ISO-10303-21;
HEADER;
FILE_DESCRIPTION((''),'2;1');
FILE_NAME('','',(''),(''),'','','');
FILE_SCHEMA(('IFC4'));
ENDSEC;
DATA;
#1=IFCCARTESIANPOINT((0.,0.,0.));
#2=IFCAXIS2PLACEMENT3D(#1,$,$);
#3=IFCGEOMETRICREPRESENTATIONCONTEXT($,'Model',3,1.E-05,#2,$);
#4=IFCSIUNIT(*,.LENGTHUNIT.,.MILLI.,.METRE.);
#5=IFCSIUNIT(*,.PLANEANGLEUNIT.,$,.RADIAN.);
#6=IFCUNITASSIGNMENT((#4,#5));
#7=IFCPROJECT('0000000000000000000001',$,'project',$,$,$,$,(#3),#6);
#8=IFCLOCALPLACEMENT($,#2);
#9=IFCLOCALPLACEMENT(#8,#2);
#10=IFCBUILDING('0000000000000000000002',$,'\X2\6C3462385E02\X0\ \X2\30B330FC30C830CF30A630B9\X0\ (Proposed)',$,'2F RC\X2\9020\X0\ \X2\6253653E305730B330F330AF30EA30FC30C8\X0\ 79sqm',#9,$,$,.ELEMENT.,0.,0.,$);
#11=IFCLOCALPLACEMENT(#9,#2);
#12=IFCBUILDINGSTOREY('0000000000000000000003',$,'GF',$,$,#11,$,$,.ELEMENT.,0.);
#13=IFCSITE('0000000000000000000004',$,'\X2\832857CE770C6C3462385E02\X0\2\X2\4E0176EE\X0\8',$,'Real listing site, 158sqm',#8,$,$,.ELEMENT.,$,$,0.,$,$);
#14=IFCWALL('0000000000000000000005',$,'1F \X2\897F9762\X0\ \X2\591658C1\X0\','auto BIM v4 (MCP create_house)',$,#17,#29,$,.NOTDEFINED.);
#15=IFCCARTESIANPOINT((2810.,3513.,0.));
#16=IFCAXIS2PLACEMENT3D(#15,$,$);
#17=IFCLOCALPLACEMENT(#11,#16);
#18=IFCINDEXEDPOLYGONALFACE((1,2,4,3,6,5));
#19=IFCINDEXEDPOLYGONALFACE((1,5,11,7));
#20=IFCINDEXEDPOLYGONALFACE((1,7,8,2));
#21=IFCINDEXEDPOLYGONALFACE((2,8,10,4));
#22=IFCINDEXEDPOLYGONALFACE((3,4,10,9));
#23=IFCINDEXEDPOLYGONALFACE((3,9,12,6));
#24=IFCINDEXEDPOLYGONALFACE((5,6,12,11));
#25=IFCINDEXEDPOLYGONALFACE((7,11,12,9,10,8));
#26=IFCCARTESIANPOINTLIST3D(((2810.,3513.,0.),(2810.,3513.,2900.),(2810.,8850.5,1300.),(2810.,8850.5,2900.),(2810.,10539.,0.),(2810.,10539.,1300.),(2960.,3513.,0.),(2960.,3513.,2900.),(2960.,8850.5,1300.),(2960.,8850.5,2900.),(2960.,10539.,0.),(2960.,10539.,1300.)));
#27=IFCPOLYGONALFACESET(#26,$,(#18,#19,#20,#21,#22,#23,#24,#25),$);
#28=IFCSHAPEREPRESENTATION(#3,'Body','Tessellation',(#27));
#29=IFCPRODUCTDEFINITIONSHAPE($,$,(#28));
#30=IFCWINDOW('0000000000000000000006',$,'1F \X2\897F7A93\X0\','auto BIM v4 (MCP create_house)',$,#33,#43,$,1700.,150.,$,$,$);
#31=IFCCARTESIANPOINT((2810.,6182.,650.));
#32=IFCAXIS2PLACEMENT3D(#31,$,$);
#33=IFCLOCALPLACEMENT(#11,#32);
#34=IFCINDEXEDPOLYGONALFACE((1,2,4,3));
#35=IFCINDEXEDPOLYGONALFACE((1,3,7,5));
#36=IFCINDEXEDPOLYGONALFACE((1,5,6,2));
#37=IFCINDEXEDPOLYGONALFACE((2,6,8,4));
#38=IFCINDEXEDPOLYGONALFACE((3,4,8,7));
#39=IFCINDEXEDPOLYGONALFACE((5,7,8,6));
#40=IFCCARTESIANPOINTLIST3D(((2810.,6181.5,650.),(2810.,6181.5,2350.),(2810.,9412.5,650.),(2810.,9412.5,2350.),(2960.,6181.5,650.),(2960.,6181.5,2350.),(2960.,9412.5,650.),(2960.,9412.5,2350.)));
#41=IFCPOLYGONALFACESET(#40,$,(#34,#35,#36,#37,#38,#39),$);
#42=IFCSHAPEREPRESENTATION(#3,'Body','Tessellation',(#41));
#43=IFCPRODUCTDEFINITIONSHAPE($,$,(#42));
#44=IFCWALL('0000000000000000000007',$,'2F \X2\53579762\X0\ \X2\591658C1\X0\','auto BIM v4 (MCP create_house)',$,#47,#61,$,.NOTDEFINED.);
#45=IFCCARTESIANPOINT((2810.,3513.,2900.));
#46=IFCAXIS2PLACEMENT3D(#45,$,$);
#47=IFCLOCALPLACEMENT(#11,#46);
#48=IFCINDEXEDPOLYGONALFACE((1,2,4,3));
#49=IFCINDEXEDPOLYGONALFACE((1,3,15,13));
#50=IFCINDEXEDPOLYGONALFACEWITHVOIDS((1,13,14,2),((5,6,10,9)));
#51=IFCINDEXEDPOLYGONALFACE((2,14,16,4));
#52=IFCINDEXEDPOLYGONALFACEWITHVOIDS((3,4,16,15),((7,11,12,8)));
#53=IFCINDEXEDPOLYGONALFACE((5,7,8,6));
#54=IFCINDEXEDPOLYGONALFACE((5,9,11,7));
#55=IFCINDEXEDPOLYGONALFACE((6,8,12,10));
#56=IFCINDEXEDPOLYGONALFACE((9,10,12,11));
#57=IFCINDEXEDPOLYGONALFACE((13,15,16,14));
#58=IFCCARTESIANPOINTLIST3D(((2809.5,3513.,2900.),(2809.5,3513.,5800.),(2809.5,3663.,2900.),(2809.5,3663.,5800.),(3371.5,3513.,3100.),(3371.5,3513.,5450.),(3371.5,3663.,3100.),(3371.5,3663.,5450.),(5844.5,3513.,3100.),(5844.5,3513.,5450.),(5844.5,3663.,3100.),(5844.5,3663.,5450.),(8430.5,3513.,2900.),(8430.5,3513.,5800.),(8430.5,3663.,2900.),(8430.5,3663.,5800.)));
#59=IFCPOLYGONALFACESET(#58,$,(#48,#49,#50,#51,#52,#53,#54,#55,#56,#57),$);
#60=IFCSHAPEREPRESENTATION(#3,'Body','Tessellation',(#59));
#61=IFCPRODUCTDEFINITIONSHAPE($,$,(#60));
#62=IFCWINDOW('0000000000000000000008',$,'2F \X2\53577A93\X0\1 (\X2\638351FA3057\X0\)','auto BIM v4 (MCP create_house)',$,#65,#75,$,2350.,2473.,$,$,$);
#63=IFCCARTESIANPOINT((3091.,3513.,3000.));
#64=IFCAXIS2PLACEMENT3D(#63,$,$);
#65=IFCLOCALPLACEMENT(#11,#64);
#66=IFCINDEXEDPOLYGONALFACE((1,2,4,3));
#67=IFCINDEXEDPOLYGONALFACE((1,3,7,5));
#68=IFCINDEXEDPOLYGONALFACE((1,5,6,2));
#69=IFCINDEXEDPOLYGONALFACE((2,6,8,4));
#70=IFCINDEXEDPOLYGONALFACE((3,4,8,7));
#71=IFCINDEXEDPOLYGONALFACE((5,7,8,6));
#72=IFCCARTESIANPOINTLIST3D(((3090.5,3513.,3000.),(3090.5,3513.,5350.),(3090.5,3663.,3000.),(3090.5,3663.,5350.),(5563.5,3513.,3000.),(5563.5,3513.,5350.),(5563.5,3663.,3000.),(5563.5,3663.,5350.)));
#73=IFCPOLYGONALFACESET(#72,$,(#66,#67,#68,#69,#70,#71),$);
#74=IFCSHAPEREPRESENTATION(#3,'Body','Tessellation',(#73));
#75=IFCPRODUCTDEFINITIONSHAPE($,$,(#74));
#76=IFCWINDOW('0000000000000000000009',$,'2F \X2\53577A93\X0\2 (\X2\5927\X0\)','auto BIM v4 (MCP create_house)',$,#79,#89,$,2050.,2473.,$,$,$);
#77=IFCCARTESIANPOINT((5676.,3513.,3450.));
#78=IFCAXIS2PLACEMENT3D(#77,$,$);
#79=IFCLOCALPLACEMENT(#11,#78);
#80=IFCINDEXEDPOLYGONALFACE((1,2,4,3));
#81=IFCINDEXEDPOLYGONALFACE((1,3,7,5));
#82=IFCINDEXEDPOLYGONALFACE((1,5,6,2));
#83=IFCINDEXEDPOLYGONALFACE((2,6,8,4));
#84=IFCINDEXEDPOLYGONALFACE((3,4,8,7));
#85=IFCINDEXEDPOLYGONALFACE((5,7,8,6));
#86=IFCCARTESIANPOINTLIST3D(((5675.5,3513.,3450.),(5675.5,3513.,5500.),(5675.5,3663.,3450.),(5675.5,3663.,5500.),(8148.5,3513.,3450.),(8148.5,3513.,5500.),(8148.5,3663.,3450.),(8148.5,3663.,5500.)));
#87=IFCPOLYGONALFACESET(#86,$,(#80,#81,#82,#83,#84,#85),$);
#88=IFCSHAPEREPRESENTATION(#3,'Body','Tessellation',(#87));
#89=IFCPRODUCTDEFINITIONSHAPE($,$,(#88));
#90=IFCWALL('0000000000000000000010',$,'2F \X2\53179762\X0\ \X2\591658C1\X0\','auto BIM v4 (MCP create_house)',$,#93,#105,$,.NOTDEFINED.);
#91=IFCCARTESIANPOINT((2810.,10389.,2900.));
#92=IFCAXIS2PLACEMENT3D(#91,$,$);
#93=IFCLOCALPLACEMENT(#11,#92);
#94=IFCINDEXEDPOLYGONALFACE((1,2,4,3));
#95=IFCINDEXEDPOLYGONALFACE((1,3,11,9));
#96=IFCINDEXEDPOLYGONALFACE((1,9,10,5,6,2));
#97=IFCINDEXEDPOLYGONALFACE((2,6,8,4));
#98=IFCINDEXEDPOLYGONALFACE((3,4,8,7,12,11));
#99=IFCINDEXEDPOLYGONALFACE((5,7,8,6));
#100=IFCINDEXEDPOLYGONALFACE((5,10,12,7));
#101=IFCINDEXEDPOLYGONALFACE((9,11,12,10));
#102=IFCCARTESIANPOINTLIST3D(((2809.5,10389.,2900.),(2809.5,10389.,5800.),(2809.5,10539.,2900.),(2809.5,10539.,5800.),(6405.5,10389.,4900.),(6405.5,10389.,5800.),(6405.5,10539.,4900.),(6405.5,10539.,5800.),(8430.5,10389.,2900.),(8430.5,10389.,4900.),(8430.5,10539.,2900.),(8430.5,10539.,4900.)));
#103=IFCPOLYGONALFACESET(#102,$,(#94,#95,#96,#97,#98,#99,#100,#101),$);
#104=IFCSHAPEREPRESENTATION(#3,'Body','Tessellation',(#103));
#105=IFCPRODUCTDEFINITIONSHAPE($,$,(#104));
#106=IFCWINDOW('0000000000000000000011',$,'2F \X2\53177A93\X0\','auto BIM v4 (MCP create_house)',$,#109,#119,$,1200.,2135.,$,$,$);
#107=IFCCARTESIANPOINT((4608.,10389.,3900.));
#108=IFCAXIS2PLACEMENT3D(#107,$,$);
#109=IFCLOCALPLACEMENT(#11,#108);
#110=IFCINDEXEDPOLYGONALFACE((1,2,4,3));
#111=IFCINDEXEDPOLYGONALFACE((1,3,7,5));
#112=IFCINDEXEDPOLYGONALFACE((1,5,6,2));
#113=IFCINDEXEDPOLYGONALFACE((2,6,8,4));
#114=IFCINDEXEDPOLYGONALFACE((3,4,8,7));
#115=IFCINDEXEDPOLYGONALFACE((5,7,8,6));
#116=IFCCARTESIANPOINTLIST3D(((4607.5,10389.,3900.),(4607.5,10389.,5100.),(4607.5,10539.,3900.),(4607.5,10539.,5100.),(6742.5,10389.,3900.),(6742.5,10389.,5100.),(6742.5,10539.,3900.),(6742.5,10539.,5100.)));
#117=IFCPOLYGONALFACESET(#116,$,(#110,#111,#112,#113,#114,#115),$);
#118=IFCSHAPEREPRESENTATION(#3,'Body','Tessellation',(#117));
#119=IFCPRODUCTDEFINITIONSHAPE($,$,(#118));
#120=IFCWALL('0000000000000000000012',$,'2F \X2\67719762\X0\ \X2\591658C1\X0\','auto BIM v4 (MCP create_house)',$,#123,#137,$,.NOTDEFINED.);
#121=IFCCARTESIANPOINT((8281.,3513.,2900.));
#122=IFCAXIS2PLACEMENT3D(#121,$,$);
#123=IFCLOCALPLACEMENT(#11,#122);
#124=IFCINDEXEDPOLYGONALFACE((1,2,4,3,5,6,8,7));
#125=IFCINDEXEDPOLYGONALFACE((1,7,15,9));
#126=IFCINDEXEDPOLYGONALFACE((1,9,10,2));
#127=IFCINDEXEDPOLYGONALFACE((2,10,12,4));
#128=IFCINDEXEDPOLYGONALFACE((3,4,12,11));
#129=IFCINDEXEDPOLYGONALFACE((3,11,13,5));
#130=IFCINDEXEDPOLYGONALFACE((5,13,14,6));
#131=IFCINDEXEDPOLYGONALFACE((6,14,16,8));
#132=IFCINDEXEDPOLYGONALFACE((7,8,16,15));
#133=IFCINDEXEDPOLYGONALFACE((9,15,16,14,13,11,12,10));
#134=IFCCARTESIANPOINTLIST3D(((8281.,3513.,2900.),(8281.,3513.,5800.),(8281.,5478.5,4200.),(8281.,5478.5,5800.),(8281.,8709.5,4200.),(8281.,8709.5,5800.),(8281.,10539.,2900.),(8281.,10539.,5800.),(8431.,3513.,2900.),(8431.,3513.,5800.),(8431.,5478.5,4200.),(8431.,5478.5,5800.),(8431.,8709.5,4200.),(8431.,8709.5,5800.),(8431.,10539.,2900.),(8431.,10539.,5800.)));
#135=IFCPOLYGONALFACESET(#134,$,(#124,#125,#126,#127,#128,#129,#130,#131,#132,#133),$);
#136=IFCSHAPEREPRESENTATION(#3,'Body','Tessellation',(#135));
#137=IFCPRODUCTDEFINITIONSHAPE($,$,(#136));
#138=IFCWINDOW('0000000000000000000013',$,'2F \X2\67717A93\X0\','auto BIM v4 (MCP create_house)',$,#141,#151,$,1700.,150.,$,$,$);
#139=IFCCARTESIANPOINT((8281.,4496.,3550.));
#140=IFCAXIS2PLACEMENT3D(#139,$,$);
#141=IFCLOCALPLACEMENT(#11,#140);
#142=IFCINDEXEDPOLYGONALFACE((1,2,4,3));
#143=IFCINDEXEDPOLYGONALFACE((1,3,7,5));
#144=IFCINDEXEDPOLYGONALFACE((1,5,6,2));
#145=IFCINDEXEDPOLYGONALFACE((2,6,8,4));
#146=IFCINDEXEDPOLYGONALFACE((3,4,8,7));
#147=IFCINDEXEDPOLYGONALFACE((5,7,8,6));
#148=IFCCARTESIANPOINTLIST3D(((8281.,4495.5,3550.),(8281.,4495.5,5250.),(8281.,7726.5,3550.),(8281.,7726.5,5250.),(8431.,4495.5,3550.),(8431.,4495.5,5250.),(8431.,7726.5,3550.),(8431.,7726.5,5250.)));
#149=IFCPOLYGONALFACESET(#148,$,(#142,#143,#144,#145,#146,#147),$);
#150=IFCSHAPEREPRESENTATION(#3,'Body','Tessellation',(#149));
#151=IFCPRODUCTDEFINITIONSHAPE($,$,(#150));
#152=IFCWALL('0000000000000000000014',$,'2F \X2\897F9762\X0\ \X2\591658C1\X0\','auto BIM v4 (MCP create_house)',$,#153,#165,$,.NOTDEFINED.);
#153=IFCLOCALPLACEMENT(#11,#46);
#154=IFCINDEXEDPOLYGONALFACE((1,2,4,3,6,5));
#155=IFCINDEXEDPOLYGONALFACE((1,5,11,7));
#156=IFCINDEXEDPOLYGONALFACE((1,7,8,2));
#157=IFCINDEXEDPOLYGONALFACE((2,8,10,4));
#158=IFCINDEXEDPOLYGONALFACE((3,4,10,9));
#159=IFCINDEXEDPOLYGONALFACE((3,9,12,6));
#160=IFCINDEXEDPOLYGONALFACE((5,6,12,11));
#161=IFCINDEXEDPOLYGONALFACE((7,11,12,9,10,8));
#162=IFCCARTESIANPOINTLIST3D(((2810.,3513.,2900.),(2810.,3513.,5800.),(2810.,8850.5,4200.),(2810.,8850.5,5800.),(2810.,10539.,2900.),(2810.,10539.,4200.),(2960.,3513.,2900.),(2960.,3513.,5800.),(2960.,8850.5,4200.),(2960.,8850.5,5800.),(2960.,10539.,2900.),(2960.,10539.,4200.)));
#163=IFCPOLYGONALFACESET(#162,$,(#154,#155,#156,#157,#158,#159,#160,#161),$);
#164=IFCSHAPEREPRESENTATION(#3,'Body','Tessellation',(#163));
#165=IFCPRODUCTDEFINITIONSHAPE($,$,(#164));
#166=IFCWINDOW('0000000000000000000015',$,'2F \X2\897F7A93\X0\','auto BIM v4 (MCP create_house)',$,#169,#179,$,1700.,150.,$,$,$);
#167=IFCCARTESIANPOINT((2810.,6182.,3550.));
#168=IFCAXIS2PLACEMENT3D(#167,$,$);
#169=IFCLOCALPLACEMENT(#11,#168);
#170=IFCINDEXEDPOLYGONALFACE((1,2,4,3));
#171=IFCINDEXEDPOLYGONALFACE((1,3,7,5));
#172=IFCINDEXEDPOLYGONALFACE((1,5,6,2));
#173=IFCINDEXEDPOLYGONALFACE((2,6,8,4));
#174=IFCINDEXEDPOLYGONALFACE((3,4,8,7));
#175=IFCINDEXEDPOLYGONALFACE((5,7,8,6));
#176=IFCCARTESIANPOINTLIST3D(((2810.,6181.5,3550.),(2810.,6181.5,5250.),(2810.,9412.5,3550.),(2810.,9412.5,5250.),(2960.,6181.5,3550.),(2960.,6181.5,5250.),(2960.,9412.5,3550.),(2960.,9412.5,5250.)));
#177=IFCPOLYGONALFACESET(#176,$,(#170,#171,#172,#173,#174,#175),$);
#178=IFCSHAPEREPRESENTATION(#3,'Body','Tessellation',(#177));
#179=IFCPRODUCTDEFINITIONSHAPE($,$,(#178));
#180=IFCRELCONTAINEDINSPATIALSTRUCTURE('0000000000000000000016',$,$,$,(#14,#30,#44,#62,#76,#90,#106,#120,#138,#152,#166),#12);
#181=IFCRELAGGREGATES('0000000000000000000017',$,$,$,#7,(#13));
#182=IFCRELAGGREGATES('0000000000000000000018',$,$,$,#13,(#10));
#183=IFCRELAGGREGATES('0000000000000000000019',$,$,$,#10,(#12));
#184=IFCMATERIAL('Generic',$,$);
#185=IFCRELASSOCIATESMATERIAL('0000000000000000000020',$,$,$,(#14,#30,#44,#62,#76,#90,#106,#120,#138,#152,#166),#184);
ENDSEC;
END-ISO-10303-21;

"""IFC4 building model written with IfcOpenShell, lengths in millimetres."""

from ifc_helpers import new_model, si_unit, frame, frame_2d, origin, place, context, project, spatial, rectangle, extrude, material, element, fill, save


model = new_model("IFC4")

# Units and contexts
model_context = context("Model", 3, precision=1e-05, world=origin())
ifc_project = project(units=[si_unit("LENGTHUNIT", "METRE", prefix="MILLI"), si_unit("PLANEANGLEUNIT", "RADIAN")], contexts=[model_context])

# Site, building, storey
site_placement = place(None, origin())
site = spatial("IfcSite", under=ifc_project, at=site_placement, Name="茨城県水戸市2丁目8", ObjectType="Real listing site, 158sqm", CompositionType="ELEMENT", RefElevation=0.0)
building_placement = place(site_placement, origin())
building = spatial("IfcBuilding", under=site, at=building_placement, Name="水戸市 コートハウス (Proposed)", ObjectType="2F RC造 打放しコンクリート 79sqm", CompositionType="ELEMENT", ElevationOfRefHeight=0.0, ElevationOfTerrain=0.0)
storey_placement = place(building_placement, origin())
storey = spatial("IfcBuildingStorey", under=building, at=storey_placement, Name="GF", CompositionType="ELEMENT", Elevation=0.0)

# Shared definitions
ifc_material = material(Name="Generic")

# Wall, opening, window
wall_1_placement = place(storey_placement, frame((2810.0, 3513.0, 0.0)))
wall_1 = element("IfcWall", 1, at=wall_1_placement, inside=storey, material=ifc_material, Name="1F 西面 外壁", Description="auto BIM v4 (MCP create_house)", PredefinedType="NOTDEFINED", context=model_context, shape_type="SweptSolid", body=[
    extrude(rectangle(XDim=150.0, YDim=7026.0, at=frame_2d((75.0, 3513.0))), frame((2810.0, 3513.0, 0.0)), (0.0, 0.0, 1.0), 2900.0),
])
opening_1_placement = place(storey_placement, frame((2810.0, 6182.0, 650.0)))
opening_1 = element("IfcOpeningElement", 2, at=opening_1_placement, cuts=wall_1, PredefinedType="NOTDEFINED", context=model_context, shape_type="SweptSolid", body=[
    extrude(rectangle(XDim=150.0, YDim=3231.0, at=frame_2d((75.0, 1615.0))), frame((2810.0, 6182.0, 650.0)), (0.0, 0.0, 1.0), 1700.0),
])
window_1_placement = place(storey_placement, frame((2810.0, 6182.0, 650.0)))
window_1 = element("IfcWindow", 3, at=window_1_placement, inside=storey, material=ifc_material, Name="1F 西窓", Description="auto BIM v4 (MCP create_house)", OverallHeight=1700.0, OverallWidth=150.0, context=model_context, shape_type="SweptSolid", body=[
    extrude(rectangle(XDim=150.0, YDim=3231.0, at=frame_2d((75.0, 1615.0))), frame((2810.0, 6182.0, 650.0)), (0.0, 0.0, 1.0), 1700.0),
])
fill(opening_1, window_1)

# Wall, openings, windows
wall_2_placement = place(storey_placement, frame((2810.0, 3513.0, 2900.0)))
wall_2 = element("IfcWall", 4, at=wall_2_placement, inside=storey, material=ifc_material, Name="2F 南面 外壁", Description="auto BIM v4 (MCP create_house)", PredefinedType="NOTDEFINED", context=model_context, shape_type="SweptSolid", body=[
    extrude(rectangle(XDim=5621.0, YDim=150.0, at=frame_2d((2810.0, 75.0))), frame((2810.0, 3513.0, 2900.0)), (0.0, 0.0, 1.0), 2900.0),
])
opening_2_placement = place(storey_placement, frame((3091.0, 3513.0, 3000.0)))
opening_2 = element("IfcOpeningElement", 5, at=opening_2_placement, cuts=wall_2, PredefinedType="NOTDEFINED", context=model_context, shape_type="SweptSolid", body=[
    extrude(rectangle(XDim=2473.0, YDim=150.0, at=frame_2d((1236.0, 75.0))), frame((3091.0, 3513.0, 3000.0)), (0.0, 0.0, 1.0), 2350.0),
])
opening_3_placement = place(storey_placement, frame((5676.0, 3513.0, 3450.0)))
opening_3 = element("IfcOpeningElement", 6, at=opening_3_placement, cuts=wall_2, PredefinedType="NOTDEFINED", context=model_context, shape_type="SweptSolid", body=[
    extrude(rectangle(XDim=2473.0, YDim=150.0, at=frame_2d((1236.0, 75.0))), frame((5676.0, 3513.0, 3450.0)), (0.0, 0.0, 1.0), 2050.0),
])
window_2_placement = place(storey_placement, frame((3091.0, 3513.0, 3000.0)))
window_2 = element("IfcWindow", 7, at=window_2_placement, inside=storey, material=ifc_material, Name="2F 南窓1 (掃出し)", Description="auto BIM v4 (MCP create_house)", OverallHeight=2350.0, OverallWidth=2473.0, context=model_context, shape_type="SweptSolid", body=[
    extrude(rectangle(XDim=2473.0, YDim=150.0, at=frame_2d((1236.0, 75.0))), frame((3091.0, 3513.0, 3000.0)), (0.0, 0.0, 1.0), 2350.0),
])
fill(opening_2, window_2)
window_3_placement = place(storey_placement, frame((5676.0, 3513.0, 3450.0)))
window_3 = element("IfcWindow", 8, at=window_3_placement, inside=storey, material=ifc_material, Name="2F 南窓2 (大)", Description="auto BIM v4 (MCP create_house)", OverallHeight=2050.0, OverallWidth=2473.0, context=model_context, shape_type="SweptSolid", body=[
    extrude(rectangle(XDim=2473.0, YDim=150.0, at=frame_2d((1236.0, 75.0))), frame((5676.0, 3513.0, 3450.0)), (0.0, 0.0, 1.0), 2050.0),
])
fill(opening_3, window_3)

# Walls, openings, windows
wall_3_placement = place(storey_placement, frame((2810.0, 10389.0, 2900.0)))
wall_3 = element("IfcWall", 9, at=wall_3_placement, inside=storey, material=ifc_material, Name="2F 北面 外壁", Description="auto BIM v4 (MCP create_house)", PredefinedType="NOTDEFINED", context=model_context, shape_type="SweptSolid", body=[
    extrude(rectangle(XDim=5621.0, YDim=150.0, at=frame_2d((2810.0, 75.0))), frame((2810.0, 10389.0, 2900.0)), (0.0, 0.0, 1.0), 2900.0),
])
opening_4_placement = place(storey_placement, frame((4608.0, 10389.0, 3900.0)))
opening_4 = element("IfcOpeningElement", 10, at=opening_4_placement, cuts=wall_3, PredefinedType="NOTDEFINED", context=model_context, shape_type="SweptSolid", body=[
    extrude(rectangle(XDim=2135.0, YDim=150.0, at=frame_2d((1067.0, 75.0))), frame((4608.0, 10389.0, 3900.0)), (0.0, 0.0, 1.0), 1200.0),
])
window_4_placement = place(storey_placement, frame((4608.0, 10389.0, 3900.0)))
window_4 = element("IfcWindow", 11, at=window_4_placement, inside=storey, material=ifc_material, Name="2F 北窓", Description="auto BIM v4 (MCP create_house)", OverallHeight=1200.0, OverallWidth=2135.0, context=model_context, shape_type="SweptSolid", body=[
    extrude(rectangle(XDim=2135.0, YDim=150.0, at=frame_2d((1067.0, 75.0))), frame((4608.0, 10389.0, 3900.0)), (0.0, 0.0, 1.0), 1200.0),
])
fill(opening_4, window_4)
wall_4_placement = place(storey_placement, frame((8281.0, 3513.0, 2900.0)))
wall_4 = element("IfcWall", 12, at=wall_4_placement, inside=storey, material=ifc_material, Name="2F 東面 外壁", Description="auto BIM v4 (MCP create_house)", PredefinedType="NOTDEFINED", context=model_context, shape_type="SweptSolid", body=[
    extrude(rectangle(XDim=150.0, YDim=7026.0, at=frame_2d((75.0, 3513.0))), frame((8281.0, 3513.0, 2900.0)), (0.0, 0.0, 1.0), 2900.0),
])
opening_5_placement = place(storey_placement, frame((8281.0, 4496.0, 3550.0)))
opening_5 = element("IfcOpeningElement", 13, at=opening_5_placement, cuts=wall_4, PredefinedType="NOTDEFINED", context=model_context, shape_type="SweptSolid", body=[
    extrude(rectangle(XDim=150.0, YDim=3231.0, at=frame_2d((75.0, 1615.0))), frame((8281.0, 4496.0, 3550.0)), (0.0, 0.0, 1.0), 1700.0),
])
window_5_placement = place(storey_placement, frame((8281.0, 4496.0, 3550.0)))
window_5 = element("IfcWindow", 14, at=window_5_placement, inside=storey, material=ifc_material, Name="2F 東窓", Description="auto BIM v4 (MCP create_house)", OverallHeight=1700.0, OverallWidth=150.0, context=model_context, shape_type="SweptSolid", body=[
    extrude(rectangle(XDim=150.0, YDim=3231.0, at=frame_2d((75.0, 1615.0))), frame((8281.0, 4496.0, 3550.0)), (0.0, 0.0, 1.0), 1700.0),
])
fill(opening_5, window_5)
wall_5_placement = place(storey_placement, frame((2810.0, 3513.0, 2900.0)))
wall_5 = element("IfcWall", 15, at=wall_5_placement, inside=storey, material=ifc_material, Name="2F 西面 外壁", Description="auto BIM v4 (MCP create_house)", PredefinedType="NOTDEFINED", context=model_context, shape_type="SweptSolid", body=[
    extrude(rectangle(XDim=150.0, YDim=7026.0, at=frame_2d((75.0, 3513.0))), frame((2810.0, 3513.0, 2900.0)), (0.0, 0.0, 1.0), 2900.0),
])
opening_6_placement = place(storey_placement, frame((2810.0, 6182.0, 3550.0)))
opening_6 = element("IfcOpeningElement", 16, at=opening_6_placement, cuts=wall_5, PredefinedType="NOTDEFINED", context=model_context, shape_type="SweptSolid", body=[
    extrude(rectangle(XDim=150.0, YDim=3231.0, at=frame_2d((75.0, 1615.0))), frame((2810.0, 6182.0, 3550.0)), (0.0, 0.0, 1.0), 1700.0),
])
window_6_placement = place(storey_placement, frame((2810.0, 6182.0, 3550.0)))
window_6 = element("IfcWindow", 17, at=window_6_placement, inside=storey, material=ifc_material, Name="2F 西窓", Description="auto BIM v4 (MCP create_house)", OverallHeight=1700.0, OverallWidth=150.0, context=model_context, shape_type="SweptSolid", body=[
    extrude(rectangle(XDim=150.0, YDim=3231.0, at=frame_2d((75.0, 1615.0))), frame((2810.0, 6182.0, 3550.0)), (0.0, 0.0, 1.0), 1700.0),
])
fill(opening_6, window_6)

save(model, "model.ifc")
